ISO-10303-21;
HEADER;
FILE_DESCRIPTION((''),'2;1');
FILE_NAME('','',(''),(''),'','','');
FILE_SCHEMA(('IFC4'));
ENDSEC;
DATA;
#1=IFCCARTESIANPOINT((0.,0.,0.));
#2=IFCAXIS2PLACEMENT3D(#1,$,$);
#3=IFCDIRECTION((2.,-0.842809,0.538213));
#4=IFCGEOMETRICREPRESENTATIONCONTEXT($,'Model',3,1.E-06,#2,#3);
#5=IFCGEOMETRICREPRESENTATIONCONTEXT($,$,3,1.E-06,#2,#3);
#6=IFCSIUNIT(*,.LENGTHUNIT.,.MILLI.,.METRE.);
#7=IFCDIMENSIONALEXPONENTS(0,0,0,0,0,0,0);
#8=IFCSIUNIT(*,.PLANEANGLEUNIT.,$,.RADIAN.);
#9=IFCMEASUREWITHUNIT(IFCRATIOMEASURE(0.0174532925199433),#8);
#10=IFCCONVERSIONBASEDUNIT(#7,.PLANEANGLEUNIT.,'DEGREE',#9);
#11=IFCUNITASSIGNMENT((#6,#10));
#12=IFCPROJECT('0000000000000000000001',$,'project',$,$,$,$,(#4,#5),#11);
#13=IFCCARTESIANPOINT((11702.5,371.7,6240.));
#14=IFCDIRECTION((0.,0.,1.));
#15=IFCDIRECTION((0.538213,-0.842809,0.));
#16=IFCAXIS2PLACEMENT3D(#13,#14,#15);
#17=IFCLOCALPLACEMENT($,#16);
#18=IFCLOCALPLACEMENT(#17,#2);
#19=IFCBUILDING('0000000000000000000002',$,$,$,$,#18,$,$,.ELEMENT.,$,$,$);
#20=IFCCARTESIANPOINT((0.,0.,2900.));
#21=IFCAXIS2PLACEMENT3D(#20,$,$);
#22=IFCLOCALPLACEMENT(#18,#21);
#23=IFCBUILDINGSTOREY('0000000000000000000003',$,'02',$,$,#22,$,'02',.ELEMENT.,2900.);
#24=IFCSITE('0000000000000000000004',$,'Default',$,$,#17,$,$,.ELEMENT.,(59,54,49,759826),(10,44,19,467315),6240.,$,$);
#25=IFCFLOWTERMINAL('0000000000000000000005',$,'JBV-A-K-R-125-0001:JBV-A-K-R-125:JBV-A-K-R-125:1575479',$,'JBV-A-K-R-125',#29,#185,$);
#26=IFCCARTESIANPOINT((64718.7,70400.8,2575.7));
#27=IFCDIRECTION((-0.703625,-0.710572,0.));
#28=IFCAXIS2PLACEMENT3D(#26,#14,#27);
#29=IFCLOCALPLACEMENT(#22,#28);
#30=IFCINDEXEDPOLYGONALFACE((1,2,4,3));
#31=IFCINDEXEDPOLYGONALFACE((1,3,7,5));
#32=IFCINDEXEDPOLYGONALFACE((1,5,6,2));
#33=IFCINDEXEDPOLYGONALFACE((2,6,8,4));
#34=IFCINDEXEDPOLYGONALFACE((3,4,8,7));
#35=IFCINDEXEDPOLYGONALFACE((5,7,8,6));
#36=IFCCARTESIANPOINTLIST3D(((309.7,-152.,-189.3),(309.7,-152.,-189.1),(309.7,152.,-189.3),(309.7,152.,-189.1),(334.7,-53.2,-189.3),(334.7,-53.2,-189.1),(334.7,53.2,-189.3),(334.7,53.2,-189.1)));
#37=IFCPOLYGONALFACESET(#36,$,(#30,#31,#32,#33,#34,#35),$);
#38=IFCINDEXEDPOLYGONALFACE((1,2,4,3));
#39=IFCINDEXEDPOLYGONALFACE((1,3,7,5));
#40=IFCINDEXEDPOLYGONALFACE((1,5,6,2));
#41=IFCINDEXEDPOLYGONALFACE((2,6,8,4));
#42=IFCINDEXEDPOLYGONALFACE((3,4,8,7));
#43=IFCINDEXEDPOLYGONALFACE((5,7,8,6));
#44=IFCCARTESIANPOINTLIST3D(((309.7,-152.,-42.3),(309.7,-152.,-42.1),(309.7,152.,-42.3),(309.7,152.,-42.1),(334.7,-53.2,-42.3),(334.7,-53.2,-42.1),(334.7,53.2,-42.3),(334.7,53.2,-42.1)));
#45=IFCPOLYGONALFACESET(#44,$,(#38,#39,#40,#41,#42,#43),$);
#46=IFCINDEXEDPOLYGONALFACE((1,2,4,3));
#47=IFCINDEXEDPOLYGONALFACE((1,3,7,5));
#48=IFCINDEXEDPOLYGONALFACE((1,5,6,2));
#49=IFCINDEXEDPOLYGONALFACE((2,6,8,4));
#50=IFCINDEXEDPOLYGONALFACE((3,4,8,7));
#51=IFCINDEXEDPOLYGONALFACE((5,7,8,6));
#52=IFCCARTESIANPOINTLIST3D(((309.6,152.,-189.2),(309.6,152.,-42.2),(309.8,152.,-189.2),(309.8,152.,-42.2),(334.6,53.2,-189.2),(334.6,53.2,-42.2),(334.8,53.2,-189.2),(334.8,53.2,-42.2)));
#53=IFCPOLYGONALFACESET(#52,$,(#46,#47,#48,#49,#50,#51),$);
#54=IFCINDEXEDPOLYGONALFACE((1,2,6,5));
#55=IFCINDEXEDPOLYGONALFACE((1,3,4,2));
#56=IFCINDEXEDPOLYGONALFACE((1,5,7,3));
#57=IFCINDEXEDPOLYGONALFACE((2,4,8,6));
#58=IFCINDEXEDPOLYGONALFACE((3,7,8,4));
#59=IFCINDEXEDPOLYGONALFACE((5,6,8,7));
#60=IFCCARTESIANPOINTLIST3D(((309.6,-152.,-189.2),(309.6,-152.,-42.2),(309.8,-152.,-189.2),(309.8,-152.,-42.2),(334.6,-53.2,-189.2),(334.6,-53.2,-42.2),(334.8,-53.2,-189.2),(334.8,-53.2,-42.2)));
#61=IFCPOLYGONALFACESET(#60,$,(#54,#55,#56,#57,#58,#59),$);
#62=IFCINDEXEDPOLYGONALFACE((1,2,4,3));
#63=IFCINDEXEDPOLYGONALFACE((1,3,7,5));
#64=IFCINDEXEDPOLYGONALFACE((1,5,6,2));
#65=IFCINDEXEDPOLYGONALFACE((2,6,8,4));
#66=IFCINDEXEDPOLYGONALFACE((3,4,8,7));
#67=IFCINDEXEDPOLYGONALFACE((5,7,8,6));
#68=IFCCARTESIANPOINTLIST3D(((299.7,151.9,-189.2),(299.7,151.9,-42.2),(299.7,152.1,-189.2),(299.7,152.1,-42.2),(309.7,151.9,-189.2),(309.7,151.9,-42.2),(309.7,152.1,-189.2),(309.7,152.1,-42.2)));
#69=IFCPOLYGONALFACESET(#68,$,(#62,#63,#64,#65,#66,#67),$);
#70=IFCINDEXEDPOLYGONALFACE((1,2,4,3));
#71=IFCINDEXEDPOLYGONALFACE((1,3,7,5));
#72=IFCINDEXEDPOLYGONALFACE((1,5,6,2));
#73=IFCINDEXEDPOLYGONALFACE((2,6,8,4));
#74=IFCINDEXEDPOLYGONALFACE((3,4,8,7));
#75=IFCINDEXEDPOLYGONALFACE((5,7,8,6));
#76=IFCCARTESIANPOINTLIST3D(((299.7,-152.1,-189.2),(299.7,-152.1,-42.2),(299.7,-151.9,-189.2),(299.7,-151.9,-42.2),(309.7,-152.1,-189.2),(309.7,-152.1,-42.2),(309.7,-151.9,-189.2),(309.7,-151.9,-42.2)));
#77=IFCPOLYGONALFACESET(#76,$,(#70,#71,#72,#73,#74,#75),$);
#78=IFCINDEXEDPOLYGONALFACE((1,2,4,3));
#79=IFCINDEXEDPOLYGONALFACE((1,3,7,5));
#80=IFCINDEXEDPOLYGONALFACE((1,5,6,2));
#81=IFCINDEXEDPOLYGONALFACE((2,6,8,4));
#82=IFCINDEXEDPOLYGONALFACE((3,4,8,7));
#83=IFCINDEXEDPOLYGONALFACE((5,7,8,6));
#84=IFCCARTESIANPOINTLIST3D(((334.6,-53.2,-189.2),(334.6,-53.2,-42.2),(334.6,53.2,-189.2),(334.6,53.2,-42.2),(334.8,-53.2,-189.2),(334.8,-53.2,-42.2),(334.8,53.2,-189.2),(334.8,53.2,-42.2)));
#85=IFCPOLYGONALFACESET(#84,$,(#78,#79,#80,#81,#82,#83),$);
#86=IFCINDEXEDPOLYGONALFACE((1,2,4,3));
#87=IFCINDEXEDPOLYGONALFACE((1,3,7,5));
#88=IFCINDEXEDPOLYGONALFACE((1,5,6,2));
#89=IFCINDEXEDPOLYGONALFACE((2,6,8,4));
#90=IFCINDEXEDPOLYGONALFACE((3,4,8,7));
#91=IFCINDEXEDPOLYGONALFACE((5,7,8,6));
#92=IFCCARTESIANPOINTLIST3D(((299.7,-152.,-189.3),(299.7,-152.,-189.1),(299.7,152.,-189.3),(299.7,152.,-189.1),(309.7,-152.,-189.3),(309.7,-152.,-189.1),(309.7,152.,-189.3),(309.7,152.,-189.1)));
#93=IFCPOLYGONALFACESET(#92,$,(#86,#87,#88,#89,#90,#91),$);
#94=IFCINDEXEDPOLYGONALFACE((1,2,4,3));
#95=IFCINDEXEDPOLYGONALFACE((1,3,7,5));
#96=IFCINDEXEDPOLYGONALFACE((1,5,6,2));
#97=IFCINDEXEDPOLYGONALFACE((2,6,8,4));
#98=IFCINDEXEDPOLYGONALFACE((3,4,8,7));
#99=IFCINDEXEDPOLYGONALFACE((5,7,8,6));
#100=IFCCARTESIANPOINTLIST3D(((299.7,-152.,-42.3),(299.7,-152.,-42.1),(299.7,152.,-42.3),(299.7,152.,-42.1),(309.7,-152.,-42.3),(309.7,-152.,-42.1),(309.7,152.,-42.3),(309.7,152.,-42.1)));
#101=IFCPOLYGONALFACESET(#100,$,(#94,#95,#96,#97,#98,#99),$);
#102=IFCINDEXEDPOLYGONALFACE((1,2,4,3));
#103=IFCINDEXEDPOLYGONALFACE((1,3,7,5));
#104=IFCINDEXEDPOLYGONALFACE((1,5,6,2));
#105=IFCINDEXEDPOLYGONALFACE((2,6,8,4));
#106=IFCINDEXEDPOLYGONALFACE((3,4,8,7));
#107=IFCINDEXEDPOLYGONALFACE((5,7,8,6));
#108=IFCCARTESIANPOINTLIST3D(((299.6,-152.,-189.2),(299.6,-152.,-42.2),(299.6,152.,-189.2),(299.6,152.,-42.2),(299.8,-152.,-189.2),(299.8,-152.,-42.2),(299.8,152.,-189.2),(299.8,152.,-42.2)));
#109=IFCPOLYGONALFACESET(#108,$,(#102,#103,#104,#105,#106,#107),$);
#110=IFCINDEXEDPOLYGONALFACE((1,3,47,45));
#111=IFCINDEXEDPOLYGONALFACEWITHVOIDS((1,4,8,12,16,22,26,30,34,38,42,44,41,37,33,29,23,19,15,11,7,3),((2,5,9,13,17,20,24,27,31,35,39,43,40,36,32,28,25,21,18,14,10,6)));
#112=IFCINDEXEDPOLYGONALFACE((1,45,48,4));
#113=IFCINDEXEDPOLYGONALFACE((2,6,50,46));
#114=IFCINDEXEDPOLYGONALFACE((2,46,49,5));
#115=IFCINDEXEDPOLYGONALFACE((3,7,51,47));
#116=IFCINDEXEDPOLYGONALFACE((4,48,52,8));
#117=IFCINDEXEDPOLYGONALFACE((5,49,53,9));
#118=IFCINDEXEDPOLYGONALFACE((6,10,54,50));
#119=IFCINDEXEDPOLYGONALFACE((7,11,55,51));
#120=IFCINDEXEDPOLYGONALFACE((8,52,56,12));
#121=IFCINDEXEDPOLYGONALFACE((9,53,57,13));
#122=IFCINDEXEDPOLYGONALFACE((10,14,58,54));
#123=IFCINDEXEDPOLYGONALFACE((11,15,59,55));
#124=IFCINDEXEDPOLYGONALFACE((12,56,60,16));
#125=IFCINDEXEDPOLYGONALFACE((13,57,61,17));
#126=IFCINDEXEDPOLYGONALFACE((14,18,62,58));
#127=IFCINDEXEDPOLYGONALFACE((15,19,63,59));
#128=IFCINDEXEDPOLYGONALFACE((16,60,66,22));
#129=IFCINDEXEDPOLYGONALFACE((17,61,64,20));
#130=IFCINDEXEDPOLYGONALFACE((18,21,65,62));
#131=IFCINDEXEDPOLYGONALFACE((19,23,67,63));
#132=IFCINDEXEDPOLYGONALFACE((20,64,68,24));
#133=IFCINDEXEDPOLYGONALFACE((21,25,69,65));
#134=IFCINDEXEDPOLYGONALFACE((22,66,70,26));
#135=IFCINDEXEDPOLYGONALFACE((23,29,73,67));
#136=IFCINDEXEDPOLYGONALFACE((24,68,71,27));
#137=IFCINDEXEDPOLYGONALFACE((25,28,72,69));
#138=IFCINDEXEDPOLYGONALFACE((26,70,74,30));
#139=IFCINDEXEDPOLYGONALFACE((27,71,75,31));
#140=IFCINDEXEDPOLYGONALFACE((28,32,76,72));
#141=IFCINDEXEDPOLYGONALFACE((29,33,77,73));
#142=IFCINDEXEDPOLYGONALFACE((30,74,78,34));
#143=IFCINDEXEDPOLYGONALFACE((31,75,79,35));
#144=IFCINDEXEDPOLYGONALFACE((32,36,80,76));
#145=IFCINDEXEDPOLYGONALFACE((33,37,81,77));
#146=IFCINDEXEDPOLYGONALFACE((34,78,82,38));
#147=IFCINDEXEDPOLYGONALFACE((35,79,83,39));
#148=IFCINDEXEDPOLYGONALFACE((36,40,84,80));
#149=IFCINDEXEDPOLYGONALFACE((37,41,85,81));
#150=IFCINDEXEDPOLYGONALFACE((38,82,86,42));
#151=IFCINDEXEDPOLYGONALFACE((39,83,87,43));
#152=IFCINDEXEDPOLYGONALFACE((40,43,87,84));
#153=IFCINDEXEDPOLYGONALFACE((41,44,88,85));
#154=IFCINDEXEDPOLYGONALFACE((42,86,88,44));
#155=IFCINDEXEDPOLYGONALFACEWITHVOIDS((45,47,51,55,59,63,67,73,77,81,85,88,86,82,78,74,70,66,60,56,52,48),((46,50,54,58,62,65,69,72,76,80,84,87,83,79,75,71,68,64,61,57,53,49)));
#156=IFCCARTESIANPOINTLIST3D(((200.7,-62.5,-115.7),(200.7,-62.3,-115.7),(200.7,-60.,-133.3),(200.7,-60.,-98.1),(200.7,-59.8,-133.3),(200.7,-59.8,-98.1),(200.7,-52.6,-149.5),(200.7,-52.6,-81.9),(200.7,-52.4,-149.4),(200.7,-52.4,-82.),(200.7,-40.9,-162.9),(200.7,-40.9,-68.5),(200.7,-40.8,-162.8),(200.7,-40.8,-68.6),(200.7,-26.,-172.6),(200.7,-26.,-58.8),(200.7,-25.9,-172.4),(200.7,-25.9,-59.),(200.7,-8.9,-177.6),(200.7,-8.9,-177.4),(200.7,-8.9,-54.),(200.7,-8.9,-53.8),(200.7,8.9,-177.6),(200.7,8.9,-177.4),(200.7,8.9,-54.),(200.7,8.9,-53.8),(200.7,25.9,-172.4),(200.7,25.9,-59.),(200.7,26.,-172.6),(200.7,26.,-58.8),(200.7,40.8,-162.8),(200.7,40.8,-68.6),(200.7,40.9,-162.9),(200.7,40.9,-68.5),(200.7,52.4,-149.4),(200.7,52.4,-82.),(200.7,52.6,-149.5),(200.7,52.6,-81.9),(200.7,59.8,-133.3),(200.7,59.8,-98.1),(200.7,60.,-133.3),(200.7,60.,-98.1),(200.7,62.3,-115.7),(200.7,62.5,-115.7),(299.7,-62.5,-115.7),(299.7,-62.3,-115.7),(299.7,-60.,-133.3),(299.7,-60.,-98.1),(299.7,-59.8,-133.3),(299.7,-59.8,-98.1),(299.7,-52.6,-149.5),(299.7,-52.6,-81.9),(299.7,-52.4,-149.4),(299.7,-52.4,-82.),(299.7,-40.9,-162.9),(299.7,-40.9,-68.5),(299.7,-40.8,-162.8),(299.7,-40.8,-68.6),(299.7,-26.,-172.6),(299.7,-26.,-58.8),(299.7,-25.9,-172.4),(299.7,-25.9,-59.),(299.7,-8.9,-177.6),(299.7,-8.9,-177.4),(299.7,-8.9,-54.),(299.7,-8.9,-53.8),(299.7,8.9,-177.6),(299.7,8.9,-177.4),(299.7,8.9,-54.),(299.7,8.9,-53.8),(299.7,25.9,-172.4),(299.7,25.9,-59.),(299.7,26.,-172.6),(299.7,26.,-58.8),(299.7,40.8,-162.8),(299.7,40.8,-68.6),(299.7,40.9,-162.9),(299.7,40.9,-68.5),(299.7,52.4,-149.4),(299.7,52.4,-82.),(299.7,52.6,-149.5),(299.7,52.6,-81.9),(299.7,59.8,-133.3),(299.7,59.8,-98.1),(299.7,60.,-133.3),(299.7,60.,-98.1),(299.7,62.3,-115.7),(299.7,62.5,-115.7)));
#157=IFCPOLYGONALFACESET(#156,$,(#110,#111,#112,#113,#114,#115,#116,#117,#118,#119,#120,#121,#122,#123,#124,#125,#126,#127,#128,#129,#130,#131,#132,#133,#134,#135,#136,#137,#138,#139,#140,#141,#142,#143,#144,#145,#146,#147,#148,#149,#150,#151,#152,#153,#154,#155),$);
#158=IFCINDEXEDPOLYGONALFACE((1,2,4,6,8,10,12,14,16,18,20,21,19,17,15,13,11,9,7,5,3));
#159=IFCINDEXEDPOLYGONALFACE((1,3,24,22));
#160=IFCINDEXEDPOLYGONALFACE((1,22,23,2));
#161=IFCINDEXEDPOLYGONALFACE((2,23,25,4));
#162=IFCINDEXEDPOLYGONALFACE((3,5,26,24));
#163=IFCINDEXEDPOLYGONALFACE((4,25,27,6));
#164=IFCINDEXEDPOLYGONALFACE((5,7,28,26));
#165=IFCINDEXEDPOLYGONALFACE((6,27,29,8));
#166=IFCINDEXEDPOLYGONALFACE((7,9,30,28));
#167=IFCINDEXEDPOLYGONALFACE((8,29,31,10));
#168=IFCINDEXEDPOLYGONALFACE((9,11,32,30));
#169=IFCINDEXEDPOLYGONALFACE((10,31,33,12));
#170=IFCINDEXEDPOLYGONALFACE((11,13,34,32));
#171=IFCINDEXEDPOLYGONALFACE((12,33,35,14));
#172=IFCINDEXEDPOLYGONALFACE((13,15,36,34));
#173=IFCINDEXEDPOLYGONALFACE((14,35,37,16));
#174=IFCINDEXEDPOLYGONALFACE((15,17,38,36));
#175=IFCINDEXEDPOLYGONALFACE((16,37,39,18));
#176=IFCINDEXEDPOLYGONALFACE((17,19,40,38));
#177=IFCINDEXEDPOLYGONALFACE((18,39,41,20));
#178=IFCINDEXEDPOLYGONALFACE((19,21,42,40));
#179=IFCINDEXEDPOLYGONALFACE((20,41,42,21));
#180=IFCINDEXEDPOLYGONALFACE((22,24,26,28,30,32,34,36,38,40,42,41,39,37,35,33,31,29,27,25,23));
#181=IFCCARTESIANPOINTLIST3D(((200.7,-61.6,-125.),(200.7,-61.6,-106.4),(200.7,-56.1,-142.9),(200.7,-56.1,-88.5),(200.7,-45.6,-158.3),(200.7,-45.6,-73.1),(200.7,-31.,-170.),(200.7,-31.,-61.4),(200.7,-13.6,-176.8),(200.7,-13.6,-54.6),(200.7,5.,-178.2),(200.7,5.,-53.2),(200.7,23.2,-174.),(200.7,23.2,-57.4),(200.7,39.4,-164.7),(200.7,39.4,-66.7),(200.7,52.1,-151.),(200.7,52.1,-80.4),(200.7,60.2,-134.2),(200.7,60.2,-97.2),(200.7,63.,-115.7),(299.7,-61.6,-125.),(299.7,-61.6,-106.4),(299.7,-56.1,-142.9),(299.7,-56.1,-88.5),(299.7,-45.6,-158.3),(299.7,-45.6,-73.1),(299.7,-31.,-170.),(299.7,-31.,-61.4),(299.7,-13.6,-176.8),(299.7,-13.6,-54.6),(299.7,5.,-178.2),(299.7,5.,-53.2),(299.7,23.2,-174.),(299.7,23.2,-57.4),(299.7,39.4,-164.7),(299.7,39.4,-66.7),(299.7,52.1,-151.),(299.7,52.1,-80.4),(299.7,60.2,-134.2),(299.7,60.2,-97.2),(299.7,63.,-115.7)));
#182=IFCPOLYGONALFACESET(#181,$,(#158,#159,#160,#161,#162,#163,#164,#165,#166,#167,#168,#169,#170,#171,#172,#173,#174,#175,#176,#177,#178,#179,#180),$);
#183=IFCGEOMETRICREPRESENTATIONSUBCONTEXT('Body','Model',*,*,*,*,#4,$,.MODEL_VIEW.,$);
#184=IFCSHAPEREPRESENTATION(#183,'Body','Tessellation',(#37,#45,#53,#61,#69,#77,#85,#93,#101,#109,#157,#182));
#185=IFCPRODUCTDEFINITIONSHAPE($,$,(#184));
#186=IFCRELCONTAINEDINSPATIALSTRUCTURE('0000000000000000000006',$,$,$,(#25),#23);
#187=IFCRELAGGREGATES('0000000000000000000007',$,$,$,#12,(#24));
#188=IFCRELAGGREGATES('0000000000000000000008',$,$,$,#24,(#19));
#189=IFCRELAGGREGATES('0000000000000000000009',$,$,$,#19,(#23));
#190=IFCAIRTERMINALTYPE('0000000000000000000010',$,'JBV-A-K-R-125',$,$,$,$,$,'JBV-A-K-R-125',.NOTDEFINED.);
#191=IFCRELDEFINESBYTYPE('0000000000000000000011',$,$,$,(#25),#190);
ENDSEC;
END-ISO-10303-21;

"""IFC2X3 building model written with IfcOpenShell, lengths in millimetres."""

from ifc_helpers import new_model, entity, si_unit, converted_unit, direction, frame, frame_2d, origin, origin_2d_with_axis, place, context, subcontext, project, spatial, polyline, circle_curve, parameter, trimmed, segment, composite_curve, rectangle, circle, outline, extrude, source, transform, mapped, type_object, type_shapes, element, save


model = new_model("IFC2X3")

# Units and contexts
model_context = context("Model", 3, precision=1e-06, world=origin(), true_north=direction((2.0, -0.842809, 0.538213)))
context_of_model = context(None, 3, precision=1e-06, world=origin(), true_north=direction((2.0, -0.842809, 0.538213)))
body_context = subcontext(model_context, "Body", "Model", "MODEL_VIEW")
ifc_project = project(units=[si_unit("LENGTHUNIT", "METRE", prefix="MILLI"), converted_unit("PLANEANGLEUNIT", "DEGREE", entity("IfcRatioMeasure", 0.0174532925199433), si_unit("PLANEANGLEUNIT", "RADIAN"), dimensions=[0, 0, 0, 0, 0, 0, 0])], contexts=[model_context, context_of_model])

# Site, building, storey
site_placement = place(None, frame((11702.5, 371.7, 6240.0), z_axis=(0.0, 0.0, 1.0), x_axis=(0.538213, -0.842809, 0.0)))
site = spatial("IfcSite", under=ifc_project, at=site_placement, Name="Default", CompositionType="ELEMENT", RefLatitude=(59, 54, 49, 759826), RefLongitude=(10, 44, 19, 467315), RefElevation=6240.0)
building_placement = place(site_placement, origin())
building = spatial("IfcBuilding", under=site, at=building_placement, CompositionType="ELEMENT")
storey_placement = place(building_placement, frame((0.0, 0.0, 2900.0)))
storey = spatial("IfcBuildingStorey", under=building, at=storey_placement, Name="02", LongName="02", CompositionType="ELEMENT", Elevation=2900.0)

# Flow terminal
air_terminal_type_1 = type_object("IfcAirTerminalType", Name="JBV-A-K-R-125", ElementType="JBV-A-K-R-125", PredefinedType="NOTDEFINED")
shared_shape_1 = source(origin(), body_context, "Body", "SweptSolid", [
    extrude(outline(polyline([(-152.0, -12.5), (152.0, -12.5), (53.2, 12.5), (-53.2, 12.5), (-152.0, -12.5)])), frame((322.2, 0.0, -189.3), z_axis=(0.0, 0.0, 1.0), x_axis=(0.0, -1.0, 0.0)), (0.0, 0.0, 1.0), 0.2),
    extrude(outline(polyline([(-152.0, -12.5), (152.0, -12.5), (53.2, 12.5), (-53.2, 12.5), (-152.0, -12.5)])), frame((322.2, 0.0, -42.3), z_axis=(0.0, 0.0, 1.0), x_axis=(0.0, -1.0, 0.0)), (0.0, 0.0, 1.0), 0.2),
    extrude(rectangle(XDim=0.2, YDim=101.9, at=frame_2d((0.0, 0.0), x_axis=(1.0, 0.0))), frame((322.2, 102.6, -189.2), z_axis=(0.0, 0.0, 1.0), x_axis=(0.969446, 0.245305, 0.0)), (0.0, 0.0, 1.0), 147.0),
    extrude(rectangle(XDim=0.2, YDim=101.9, at=frame_2d((0.0, 0.0), x_axis=(1.0, 0.0))), frame((322.2, -102.6, -189.2), z_axis=(0.0, 0.0, 1.0), x_axis=(-0.969446, 0.245305, 0.0)), (0.0, 0.0, 1.0), 147.0),
    extrude(rectangle(XDim=0.2, YDim=10.0, at=frame_2d((0.0, 0.0), x_axis=(1.0, 0.0))), frame((304.7, 152.0, -189.2), z_axis=(0.0, 0.0, 1.0), x_axis=(0.0, 1.0, 0.0)), (0.0, 0.0, 1.0), 147.0),
    extrude(rectangle(XDim=0.2, YDim=10.0, at=frame_2d((0.0, 0.0), x_axis=(1.0, 0.0))), frame((304.7, -152.0, -189.2), z_axis=(0.0, 0.0, 1.0), x_axis=(0.0, 1.0, 0.0)), (0.0, 0.0, 1.0), 147.0),
    extrude(rectangle(XDim=0.2, YDim=106.4, at=frame_2d((0.0, 0.0), x_axis=(1.0, 0.0))), frame((334.7, 0.0, -189.2)), (0.0, 0.0, 1.0), 147.0),
    extrude(rectangle(XDim=304.0, YDim=10.0, at=frame_2d((0.0, 0.0), x_axis=(1.0, 0.0))), frame((304.7, 0.0, -189.3), z_axis=(0.0, 0.0, 1.0), x_axis=(0.0, -1.0, 0.0)), (0.0, 0.0, 1.0), 0.2),
    extrude(rectangle(XDim=304.0, YDim=10.0, at=frame_2d((0.0, 0.0), x_axis=(1.0, 0.0))), frame((304.7, 0.0, -42.3), z_axis=(0.0, 0.0, 1.0), x_axis=(0.0, -1.0, 0.0)), (0.0, 0.0, 1.0), 0.2),
    extrude(rectangle(XDim=0.2, YDim=304.0, at=frame_2d((0.0, 0.0), x_axis=(1.0, 0.0))), frame((299.7, 0.0, -189.2)), (0.0, 0.0, 1.0), 147.0),
    extrude(outline(composite_curve([segment(trimmed(circle_curve(origin_2d_with_axis(), 62.5), [parameter(0.0)], [parameter(180.0)], True, "PARAMETER"), True, "CONTINUOUS"), segment(trimmed(circle_curve(origin_2d_with_axis(), 62.5), [parameter(180.0)], [parameter(360.0)], True, "PARAMETER"), True, "CONTINUOUS")], self_intersect=False), holes=[composite_curve([segment(trimmed(circle_curve(origin_2d_with_axis(), 62.3), [parameter(180.0)], [parameter(360.0)], True, "PARAMETER"), False, "CONTINUOUS"), segment(trimmed(circle_curve(origin_2d_with_axis(), 62.3), [parameter(0.0)], [parameter(180.0)], True, "PARAMETER"), False, "CONTINUOUS")], self_intersect=False)]), frame((200.7, 0.0, -115.7), z_axis=(1.0, 0.0, 0.0), x_axis=(0.0, 1.0, 0.0)), (0.0, 0.0, 1.0), 99.0),
    extrude(circle(Radius=62.6, at=frame_2d((0.0, 0.0), x_axis=(1.0, 0.0))), frame((200.7, 0.3, -115.7), z_axis=(1.0, 0.0, 0.0), x_axis=(0.0, 1.0, 0.0)), (0.0, 0.0, 1.0), 99.0),
])
type_shapes(air_terminal_type_1, [shared_shape_1])
flow_terminal_1_placement = place(storey_placement, frame((64718.7, 70400.8, 2575.7), z_axis=(0.0, 0.0, 1.0), x_axis=(-0.703625, -0.710572, 0.0)))
element("IfcFlowTerminal", 1, at=flow_terminal_1_placement, inside=storey, type_object=air_terminal_type_1, Name="JBV-A-K-R-125-0001:JBV-A-K-R-125:JBV-A-K-R-125:1575479", ObjectType="JBV-A-K-R-125", context=body_context, shape_type="MappedRepresentation", body=[
    mapped(shared_shape_1, transform((0.0, 0.0, 0.0), scale=1.0)),
])

save(model, "model.ifc")
